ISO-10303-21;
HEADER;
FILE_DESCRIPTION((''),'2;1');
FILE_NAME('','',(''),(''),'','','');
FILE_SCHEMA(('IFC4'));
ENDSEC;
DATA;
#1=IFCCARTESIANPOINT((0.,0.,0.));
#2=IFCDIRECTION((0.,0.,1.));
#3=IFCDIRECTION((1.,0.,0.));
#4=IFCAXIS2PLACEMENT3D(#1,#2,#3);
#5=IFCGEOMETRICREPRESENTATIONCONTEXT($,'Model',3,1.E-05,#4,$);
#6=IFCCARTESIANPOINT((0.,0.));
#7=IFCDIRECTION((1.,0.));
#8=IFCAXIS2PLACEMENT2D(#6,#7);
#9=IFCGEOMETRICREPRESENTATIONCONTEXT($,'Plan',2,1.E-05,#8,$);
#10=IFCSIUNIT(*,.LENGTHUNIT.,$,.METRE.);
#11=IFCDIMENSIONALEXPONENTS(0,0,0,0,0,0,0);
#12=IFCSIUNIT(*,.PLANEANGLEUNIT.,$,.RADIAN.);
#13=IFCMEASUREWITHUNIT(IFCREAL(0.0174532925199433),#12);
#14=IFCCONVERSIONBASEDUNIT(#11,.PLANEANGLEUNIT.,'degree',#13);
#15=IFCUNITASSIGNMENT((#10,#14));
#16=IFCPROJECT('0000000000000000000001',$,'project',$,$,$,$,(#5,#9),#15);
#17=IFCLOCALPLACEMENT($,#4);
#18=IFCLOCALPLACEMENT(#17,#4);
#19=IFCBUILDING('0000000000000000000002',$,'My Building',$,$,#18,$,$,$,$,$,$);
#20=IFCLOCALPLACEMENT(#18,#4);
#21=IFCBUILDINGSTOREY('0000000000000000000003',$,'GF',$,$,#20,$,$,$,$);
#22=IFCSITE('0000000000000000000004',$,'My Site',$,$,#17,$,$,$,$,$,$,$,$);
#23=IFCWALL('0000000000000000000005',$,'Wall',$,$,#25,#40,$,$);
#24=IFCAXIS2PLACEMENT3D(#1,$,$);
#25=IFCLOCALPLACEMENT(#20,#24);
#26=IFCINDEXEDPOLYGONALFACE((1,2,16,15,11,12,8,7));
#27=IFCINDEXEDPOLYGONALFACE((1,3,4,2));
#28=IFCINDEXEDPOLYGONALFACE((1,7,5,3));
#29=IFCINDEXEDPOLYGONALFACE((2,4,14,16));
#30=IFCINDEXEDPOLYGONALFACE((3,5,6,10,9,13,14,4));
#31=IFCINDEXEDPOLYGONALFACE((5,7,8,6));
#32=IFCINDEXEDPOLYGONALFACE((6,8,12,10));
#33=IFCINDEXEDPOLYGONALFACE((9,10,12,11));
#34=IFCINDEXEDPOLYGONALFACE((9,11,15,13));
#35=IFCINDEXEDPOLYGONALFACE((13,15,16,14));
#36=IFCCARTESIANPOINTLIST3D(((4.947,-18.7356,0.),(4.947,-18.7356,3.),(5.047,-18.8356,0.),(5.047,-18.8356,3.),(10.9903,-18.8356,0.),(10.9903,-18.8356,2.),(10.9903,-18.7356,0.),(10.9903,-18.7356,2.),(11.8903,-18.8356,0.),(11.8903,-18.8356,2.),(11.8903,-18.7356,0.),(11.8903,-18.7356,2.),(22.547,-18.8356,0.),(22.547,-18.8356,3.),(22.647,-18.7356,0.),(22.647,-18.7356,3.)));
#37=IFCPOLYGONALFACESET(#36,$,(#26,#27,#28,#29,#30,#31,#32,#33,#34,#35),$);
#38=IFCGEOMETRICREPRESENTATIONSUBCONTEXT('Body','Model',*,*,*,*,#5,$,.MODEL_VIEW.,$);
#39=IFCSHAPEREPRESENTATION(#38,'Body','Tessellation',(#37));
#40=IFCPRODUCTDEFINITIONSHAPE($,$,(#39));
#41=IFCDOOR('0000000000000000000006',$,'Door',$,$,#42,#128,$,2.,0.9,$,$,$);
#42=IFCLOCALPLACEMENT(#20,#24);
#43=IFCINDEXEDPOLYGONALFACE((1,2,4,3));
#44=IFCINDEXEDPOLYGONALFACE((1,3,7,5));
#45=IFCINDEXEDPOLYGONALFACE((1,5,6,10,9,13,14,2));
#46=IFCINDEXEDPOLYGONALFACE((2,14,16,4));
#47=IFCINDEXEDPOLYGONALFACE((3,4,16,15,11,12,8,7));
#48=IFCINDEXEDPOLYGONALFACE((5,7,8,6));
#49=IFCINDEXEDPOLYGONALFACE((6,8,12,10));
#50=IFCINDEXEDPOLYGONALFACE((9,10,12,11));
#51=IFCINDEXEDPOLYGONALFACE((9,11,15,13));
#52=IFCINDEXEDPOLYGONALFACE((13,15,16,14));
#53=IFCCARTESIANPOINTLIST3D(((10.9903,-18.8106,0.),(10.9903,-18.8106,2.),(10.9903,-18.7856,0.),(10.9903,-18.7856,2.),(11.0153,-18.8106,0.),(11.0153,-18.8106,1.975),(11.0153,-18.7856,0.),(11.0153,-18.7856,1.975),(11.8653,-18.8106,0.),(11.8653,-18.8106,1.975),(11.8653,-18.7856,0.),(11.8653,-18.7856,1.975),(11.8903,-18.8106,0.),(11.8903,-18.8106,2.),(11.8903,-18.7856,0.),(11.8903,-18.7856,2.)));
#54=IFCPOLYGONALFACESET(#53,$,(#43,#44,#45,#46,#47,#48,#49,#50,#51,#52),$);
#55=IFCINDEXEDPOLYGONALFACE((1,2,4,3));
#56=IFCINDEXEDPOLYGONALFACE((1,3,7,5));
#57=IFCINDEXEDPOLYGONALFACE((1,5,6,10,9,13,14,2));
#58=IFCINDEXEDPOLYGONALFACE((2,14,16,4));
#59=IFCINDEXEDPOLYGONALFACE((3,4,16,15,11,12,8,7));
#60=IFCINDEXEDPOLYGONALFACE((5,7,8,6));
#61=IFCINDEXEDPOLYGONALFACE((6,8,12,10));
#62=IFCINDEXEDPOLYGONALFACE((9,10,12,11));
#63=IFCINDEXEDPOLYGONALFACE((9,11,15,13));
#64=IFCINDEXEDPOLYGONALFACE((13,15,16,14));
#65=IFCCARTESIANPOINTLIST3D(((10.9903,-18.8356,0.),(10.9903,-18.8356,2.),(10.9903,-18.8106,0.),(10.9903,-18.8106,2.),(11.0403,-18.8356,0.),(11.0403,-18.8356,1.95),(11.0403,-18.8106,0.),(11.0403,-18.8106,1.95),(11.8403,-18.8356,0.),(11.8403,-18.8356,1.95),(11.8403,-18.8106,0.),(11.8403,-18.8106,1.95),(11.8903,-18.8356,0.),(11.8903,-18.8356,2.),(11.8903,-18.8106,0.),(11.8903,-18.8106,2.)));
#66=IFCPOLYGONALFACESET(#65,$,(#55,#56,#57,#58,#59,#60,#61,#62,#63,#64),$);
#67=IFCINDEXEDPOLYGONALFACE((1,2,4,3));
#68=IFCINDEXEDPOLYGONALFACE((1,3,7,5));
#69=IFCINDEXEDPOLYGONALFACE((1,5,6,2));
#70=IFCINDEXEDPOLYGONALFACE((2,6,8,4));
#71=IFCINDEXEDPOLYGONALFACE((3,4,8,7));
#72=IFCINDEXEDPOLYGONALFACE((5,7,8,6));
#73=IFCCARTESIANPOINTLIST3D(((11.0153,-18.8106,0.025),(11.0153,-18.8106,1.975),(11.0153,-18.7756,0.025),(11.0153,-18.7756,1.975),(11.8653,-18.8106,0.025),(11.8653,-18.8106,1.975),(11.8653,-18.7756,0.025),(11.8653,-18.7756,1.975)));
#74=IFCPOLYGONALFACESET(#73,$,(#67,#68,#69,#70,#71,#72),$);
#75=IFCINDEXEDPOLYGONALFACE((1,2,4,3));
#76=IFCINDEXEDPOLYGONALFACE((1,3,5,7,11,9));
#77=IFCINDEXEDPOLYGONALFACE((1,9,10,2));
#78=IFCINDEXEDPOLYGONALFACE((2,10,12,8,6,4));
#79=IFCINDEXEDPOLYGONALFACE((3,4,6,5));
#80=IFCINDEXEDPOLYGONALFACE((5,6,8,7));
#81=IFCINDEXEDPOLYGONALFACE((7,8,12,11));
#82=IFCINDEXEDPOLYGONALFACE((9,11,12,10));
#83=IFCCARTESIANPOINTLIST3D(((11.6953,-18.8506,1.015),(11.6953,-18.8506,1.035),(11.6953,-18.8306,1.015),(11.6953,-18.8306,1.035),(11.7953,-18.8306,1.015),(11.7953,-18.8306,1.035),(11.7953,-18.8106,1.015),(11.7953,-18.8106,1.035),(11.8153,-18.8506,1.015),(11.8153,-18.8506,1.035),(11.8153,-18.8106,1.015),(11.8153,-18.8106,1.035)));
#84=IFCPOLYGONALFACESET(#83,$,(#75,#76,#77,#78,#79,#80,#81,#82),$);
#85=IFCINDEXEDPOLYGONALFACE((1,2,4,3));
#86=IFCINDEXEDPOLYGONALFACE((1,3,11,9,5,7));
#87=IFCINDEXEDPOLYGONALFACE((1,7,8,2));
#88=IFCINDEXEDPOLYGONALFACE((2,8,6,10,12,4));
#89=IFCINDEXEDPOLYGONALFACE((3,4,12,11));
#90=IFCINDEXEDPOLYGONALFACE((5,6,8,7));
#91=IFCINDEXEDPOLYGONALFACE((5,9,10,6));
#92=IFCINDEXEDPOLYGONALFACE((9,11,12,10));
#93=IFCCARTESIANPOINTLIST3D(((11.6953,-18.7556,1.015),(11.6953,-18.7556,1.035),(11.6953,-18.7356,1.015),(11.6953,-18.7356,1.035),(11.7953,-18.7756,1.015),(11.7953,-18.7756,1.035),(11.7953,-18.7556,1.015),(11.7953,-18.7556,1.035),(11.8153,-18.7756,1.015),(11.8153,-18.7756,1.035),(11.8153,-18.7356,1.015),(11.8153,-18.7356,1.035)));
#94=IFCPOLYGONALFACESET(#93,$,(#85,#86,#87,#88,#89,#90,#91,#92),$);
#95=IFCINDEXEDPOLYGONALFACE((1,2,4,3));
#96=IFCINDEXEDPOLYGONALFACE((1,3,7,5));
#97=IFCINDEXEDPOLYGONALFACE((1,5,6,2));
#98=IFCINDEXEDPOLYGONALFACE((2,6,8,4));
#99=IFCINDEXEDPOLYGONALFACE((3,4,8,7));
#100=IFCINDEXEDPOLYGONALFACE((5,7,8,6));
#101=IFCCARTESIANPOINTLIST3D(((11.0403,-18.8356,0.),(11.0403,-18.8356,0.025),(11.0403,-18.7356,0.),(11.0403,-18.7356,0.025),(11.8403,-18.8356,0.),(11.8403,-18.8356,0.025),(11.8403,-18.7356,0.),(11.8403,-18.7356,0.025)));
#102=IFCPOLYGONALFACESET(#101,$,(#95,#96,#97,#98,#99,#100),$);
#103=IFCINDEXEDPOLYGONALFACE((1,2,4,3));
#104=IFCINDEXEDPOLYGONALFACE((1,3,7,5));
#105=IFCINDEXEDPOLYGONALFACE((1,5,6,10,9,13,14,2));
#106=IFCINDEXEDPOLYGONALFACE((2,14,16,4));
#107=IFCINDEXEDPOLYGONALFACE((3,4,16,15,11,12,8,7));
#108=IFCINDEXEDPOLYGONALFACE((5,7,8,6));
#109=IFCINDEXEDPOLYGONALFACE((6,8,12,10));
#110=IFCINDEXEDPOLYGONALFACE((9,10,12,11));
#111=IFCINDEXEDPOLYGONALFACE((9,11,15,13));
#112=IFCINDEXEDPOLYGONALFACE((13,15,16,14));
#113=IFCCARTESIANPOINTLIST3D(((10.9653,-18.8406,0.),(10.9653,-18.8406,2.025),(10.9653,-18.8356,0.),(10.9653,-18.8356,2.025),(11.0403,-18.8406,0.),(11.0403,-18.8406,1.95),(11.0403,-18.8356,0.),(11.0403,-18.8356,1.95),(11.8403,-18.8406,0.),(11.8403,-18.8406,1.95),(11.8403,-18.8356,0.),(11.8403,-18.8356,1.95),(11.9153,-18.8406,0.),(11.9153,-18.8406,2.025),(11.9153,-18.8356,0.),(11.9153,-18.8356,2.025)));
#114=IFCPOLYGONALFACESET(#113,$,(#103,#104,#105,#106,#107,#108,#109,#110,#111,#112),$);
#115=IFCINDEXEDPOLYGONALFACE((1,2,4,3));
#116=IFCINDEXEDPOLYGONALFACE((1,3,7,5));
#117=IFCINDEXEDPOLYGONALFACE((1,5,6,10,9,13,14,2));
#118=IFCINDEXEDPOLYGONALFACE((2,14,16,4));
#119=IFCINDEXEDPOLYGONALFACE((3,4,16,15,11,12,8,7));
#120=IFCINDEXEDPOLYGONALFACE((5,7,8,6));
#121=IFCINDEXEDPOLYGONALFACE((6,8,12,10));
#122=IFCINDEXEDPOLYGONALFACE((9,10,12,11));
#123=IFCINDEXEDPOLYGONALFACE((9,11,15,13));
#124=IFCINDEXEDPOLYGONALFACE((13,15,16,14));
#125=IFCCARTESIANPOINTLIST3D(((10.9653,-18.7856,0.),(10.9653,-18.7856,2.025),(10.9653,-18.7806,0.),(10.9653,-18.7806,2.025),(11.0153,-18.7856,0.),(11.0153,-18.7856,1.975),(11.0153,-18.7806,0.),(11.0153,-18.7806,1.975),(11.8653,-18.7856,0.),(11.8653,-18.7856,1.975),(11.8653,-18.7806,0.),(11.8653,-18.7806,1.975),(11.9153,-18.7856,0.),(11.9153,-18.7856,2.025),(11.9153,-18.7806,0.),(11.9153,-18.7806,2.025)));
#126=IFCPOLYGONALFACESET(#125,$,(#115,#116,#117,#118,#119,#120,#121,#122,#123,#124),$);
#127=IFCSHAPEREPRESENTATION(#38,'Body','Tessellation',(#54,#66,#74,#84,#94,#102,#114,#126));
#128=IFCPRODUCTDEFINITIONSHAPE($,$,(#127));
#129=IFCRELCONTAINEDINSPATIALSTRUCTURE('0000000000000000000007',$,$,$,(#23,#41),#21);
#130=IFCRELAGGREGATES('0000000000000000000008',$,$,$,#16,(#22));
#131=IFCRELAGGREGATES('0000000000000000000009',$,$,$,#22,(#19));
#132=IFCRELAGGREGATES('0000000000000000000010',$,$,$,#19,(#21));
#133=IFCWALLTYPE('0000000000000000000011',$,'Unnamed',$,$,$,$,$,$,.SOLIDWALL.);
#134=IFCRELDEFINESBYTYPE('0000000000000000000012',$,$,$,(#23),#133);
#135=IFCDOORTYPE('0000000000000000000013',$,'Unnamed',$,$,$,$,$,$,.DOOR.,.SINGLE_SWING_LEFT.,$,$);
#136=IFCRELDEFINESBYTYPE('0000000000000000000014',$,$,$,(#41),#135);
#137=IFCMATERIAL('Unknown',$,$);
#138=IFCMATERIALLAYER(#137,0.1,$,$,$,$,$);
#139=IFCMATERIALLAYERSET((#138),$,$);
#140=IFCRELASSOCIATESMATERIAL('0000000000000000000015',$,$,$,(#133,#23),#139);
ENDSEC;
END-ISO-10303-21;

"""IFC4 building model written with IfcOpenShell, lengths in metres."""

from ifc_helpers import new_model, entity, si_unit, converted_unit, frame, origin_with_axes, origin_2d_with_axis, place, context, subcontext, project, spatial, line, indexed_curve, outline, extrude, shape, source, transform, mapped, material, layer, layer_set, layer_usage, type_object, type_shapes, element, fill, save


model = new_model("IFC4")

# Units and contexts
model_context = context("Model", 3, precision=1e-05, world=origin_with_axes())
plan_context = context("Plan", 2, precision=1e-05, world=origin_2d_with_axis())
body_context_1 = subcontext(model_context, "Body", "Model", "MODEL_VIEW")
body_context_2 = subcontext(plan_context, "Body", "Plan", "PLAN_VIEW")
ifc_project = project(units=[si_unit("LENGTHUNIT", "METRE"), converted_unit("PLANEANGLEUNIT", "degree", entity("IfcReal", 0.0174532925199433), si_unit("PLANEANGLEUNIT", "RADIAN"), dimensions=[0, 0, 0, 0, 0, 0, 0])], contexts=[model_context, plan_context])

# Site, building, storey
site_placement = place(None, origin_with_axes())
site = spatial("IfcSite", under=ifc_project, at=site_placement, Name="My Site")
building_placement = place(site_placement, origin_with_axes())
building = spatial("IfcBuilding", under=site, at=building_placement, Name="My Building")
storey_placement = place(building_placement, origin_with_axes())
storey = spatial("IfcBuildingStorey", under=building, at=storey_placement, Name="GF")

# Shared definitions
ifc_material = material(Name="Unknown")

# Shared definitions
ifc_layer_1 = layer(ifc_material, 0.1)
ifc_layer_set_1 = layer_set([ifc_layer_1])
wall_type = type_object("IfcWallType", Name="Unnamed", PredefinedType="SOLIDWALL", material=ifc_layer_set_1)

# Shared definitions
shared_shape_1 = source(origin_with_axes(), body_context_1, "Body", "SweptSolid", [
    extrude(outline(indexed_curve([(0.0, 0.0), (0.9, 0.0), (0.9, 2.0), (0.0, 2.0)], segments=[line(1, 2, 3, 4, 1)])), frame((0.0, -0.6, 0.0), z_axis=(0.0, -1.0, 0.0), x_axis=(1.0, 0.0, 0.0)), (0.0, 0.0, -1.0), 1.2),
])
door_type = type_object("IfcDoorType", Name="Unnamed", OperationType="SINGLE_SWING_LEFT", PredefinedType="DOOR")
shared_shape_2 = source(origin_with_axes(), body_context_1, "Body", "SweptSolid", [
    extrude(outline(indexed_curve([(0.0, 0.0), (0.0, 2.0), (0.9, 2.0), (0.9, 0.0), (0.875, 0.0), (0.875, 1.975), (0.025, 1.975), (0.025, 0.0)], segments=[line(1, 2, 3, 4, 5, 6, 7, 8, 1)])), frame((0.0, 0.025, 0.0), z_axis=(0.0, -1.0, 0.0), x_axis=(1.0, 0.0, 0.0)), (0.0, 0.0, -1.0), 0.025),
    extrude(outline(indexed_curve([(0.0, 0.0), (0.0, 2.0), (0.9, 2.0), (0.9, 0.0), (0.85, 0.0), (0.85, 1.95), (0.05, 1.95), (0.05, 0.0)], segments=[line(1, 2, 3, 4, 5, 6, 7, 8, 1)])), frame((0.0, 0.0, 0.0), z_axis=(0.0, -1.0, 0.0), x_axis=(1.0, 0.0, 0.0)), (0.0, 0.0, -1.0), 0.025),
    extrude(outline(indexed_curve([(0.0, 0.0), (0.85, 0.0), (0.85, 0.035), (0.0, 0.035)], segments=[line(1, 2, 3, 4, 1)])), frame((0.025, 0.025, 0.025), z_axis=(0.0, 0.0, 1.0), x_axis=(1.0, 0.0, 0.0)), (0.0, 0.0, 1.0), 1.95),
    extrude(outline(indexed_curve([(0.0, 0.0), (0.0, -0.04), (-0.12, -0.04), (-0.12, -0.02), (-0.02, -0.02), (-0.02, 0.0)], segments=[line(1, 2, 3, 4, 5, 6, 1)])), frame((0.825, 0.025, 1.015), z_axis=(0.0, 0.0, 1.0), x_axis=(1.0, 0.0, 0.0)), (0.0, 0.0, 1.0), 0.02),
    extrude(outline(indexed_curve([(0.0, 0.0), (0.0, 0.04), (-0.12, 0.04), (-0.12, 0.02), (-0.02, 0.02), (-0.02, 0.0)], segments=[line(1, 2, 3, 4, 5, 6, 1)])), frame((0.825, 0.06, 1.015), z_axis=(0.0, 0.0, 1.0), x_axis=(1.0, 0.0, 0.0)), (0.0, 0.0, 1.0), 0.02),
    extrude(outline(indexed_curve([(0.0, 0.0), (0.8, 0.0), (0.8, 0.1), (0.0, 0.1)], segments=[line(1, 2, 3, 4, 1)])), frame((0.05, 0.0, 0.0), z_axis=(0.0, 0.0, 1.0), x_axis=(1.0, 0.0, 0.0)), (0.0, 0.0, 1.0), 0.025),
    extrude(outline(indexed_curve([(0.0, 0.0), (0.0, 2.025), (0.95, 2.025), (0.95, 0.0), (0.875, 0.0), (0.875, 1.95), (0.075, 1.95), (0.075, 0.0)], segments=[line(1, 2, 3, 4, 5, 6, 7, 8, 1)])), frame((-0.025, -0.005, 0.0), z_axis=(0.0, -1.0, 0.0), x_axis=(1.0, 0.0, 0.0)), (0.0, 0.0, -1.0), 0.005),
    extrude(outline(indexed_curve([(0.0, 0.0), (0.0, 2.025), (0.95, 2.025), (0.95, 0.0), (0.9, 0.0), (0.9, 1.975), (0.05, 1.975), (0.05, 0.0)], segments=[line(1, 2, 3, 4, 5, 6, 7, 8, 1)])), frame((-0.025, 0.05, 0.0), z_axis=(0.0, -1.0, 0.0), x_axis=(1.0, 0.0, 0.0)), (0.0, 0.0, -1.0), 0.005),
])
shared_shape_3 = source(origin_with_axes(), body_context_2, "Body", "Curve2D", [
    entity("IfcIndexedPolyCurve", entity("IfcCartesianPointList2D", [[0.0, 0.0], [0.0, 0.05], [0.025, 0.05], [0.025, 0.025], [0.05, 0.025], [0.05, 0.0]]), [entity("IfcLineIndex", [1, 2, 3, 4, 5, 6, 1])]),
    entity("IfcIndexedPolyCurve", entity("IfcCartesianPointList2D", [[0.9, 0.0], [0.9, 0.05], [0.875, 0.05], [0.875, 0.025], [0.85, 0.025], [0.85, 0.0]]), [entity("IfcLineIndex", [1, 2, 3, 4, 5, 6, 1])]),
    entity("IfcTrimmedCurve", entity("IfcEllipse", entity("IfcAxis2Placement2D", entity("IfcCartesianPoint", [0.06, 0.05]), entity("IfcDirection", [1.0, 0.0])), 0.815, 0.85), [entity("IfcCartesianPoint", [0.875, 0.05])], [entity("IfcCartesianPoint", [0.06, 0.9])], True, "CARTESIAN"),
    entity("IfcIndexedPolyCurve", entity("IfcCartesianPointList2D", [[0.025, 0.05], [0.06, 0.05], [0.06, 0.9], [0.025, 0.9]]), [entity("IfcLineIndex", [1, 2, 3, 4, 1])]),
])
type_shapes(door_type, [shared_shape_2, shared_shape_3])

# Wall, opening, door
ifc_layer_usage_1 = layer_usage(ifc_layer_set_1, "AXIS2", "POSITIVE", 0.0)
wall_1_placement = place(storey_placement, frame((5.047, -18.8356, 0.0), z_axis=(0.0, 0.0, 1.0), x_axis=(1.0, 0.0, 0.0)))
wall_1 = element("IfcWall", 1, at=wall_1_placement, inside=storey, type_object=wall_type, material=ifc_layer_usage_1, Name="Wall", context=body_context_1, shape_type="SweptSolid", body=[
    extrude(outline(indexed_curve([(0.0, 0.0), (-0.1, 0.1), (17.6, 0.1), (17.5, 0.0)], segments=[line(1, 2, 3, 4, 1)])), origin_with_axes(), (0.0, 0.0, 1.0), 3.0),
])
opening_1_placement = place(wall_1_placement, frame((5.9433, 0.0, 0.0), z_axis=(0.0, 0.0, 1.0), x_axis=(1.0, 0.0, 0.0)))
opening_1 = element("IfcOpeningElement", 2, at=opening_1_placement, cuts=wall_1, PredefinedType="OPENING", context=body_context_1, shape_type="MappedRepresentation", body=[
    mapped(shared_shape_1, transform((0.0, 0.0, 0.0), x_axis=(1.0, 0.0, 0.0), y_axis=(0.0, 1.0, 0.0), z_axis=(0.0, 0.0, 1.0), scale=1.0)),
])
door_1_placement = place(opening_1_placement, origin_with_axes())
door_1 = element("IfcDoor", 3, at=door_1_placement, inside=storey, type_object=door_type, Name="Door", OverallHeight=2.0, OverallWidth=0.9, shapes=[
    shape(body_context_1, "Body", "MappedRepresentation", [mapped(shared_shape_2, transform((0.0, 0.0, 0.0), x_axis=(1.0, 0.0, 0.0), y_axis=(0.0, 1.0, 0.0), z_axis=(0.0, 0.0, 1.0), scale=1.0))]),
    shape(body_context_2, "Body", "MappedRepresentation", [mapped(shared_shape_3, transform((0.0, 0.0, 0.0), x_axis=(1.0, 0.0, 0.0), y_axis=(0.0, 1.0, 0.0), z_axis=(0.0, 0.0, 1.0), scale=1.0))]),
])
fill(opening_1, door_1)

save(model, "model.ifc")
